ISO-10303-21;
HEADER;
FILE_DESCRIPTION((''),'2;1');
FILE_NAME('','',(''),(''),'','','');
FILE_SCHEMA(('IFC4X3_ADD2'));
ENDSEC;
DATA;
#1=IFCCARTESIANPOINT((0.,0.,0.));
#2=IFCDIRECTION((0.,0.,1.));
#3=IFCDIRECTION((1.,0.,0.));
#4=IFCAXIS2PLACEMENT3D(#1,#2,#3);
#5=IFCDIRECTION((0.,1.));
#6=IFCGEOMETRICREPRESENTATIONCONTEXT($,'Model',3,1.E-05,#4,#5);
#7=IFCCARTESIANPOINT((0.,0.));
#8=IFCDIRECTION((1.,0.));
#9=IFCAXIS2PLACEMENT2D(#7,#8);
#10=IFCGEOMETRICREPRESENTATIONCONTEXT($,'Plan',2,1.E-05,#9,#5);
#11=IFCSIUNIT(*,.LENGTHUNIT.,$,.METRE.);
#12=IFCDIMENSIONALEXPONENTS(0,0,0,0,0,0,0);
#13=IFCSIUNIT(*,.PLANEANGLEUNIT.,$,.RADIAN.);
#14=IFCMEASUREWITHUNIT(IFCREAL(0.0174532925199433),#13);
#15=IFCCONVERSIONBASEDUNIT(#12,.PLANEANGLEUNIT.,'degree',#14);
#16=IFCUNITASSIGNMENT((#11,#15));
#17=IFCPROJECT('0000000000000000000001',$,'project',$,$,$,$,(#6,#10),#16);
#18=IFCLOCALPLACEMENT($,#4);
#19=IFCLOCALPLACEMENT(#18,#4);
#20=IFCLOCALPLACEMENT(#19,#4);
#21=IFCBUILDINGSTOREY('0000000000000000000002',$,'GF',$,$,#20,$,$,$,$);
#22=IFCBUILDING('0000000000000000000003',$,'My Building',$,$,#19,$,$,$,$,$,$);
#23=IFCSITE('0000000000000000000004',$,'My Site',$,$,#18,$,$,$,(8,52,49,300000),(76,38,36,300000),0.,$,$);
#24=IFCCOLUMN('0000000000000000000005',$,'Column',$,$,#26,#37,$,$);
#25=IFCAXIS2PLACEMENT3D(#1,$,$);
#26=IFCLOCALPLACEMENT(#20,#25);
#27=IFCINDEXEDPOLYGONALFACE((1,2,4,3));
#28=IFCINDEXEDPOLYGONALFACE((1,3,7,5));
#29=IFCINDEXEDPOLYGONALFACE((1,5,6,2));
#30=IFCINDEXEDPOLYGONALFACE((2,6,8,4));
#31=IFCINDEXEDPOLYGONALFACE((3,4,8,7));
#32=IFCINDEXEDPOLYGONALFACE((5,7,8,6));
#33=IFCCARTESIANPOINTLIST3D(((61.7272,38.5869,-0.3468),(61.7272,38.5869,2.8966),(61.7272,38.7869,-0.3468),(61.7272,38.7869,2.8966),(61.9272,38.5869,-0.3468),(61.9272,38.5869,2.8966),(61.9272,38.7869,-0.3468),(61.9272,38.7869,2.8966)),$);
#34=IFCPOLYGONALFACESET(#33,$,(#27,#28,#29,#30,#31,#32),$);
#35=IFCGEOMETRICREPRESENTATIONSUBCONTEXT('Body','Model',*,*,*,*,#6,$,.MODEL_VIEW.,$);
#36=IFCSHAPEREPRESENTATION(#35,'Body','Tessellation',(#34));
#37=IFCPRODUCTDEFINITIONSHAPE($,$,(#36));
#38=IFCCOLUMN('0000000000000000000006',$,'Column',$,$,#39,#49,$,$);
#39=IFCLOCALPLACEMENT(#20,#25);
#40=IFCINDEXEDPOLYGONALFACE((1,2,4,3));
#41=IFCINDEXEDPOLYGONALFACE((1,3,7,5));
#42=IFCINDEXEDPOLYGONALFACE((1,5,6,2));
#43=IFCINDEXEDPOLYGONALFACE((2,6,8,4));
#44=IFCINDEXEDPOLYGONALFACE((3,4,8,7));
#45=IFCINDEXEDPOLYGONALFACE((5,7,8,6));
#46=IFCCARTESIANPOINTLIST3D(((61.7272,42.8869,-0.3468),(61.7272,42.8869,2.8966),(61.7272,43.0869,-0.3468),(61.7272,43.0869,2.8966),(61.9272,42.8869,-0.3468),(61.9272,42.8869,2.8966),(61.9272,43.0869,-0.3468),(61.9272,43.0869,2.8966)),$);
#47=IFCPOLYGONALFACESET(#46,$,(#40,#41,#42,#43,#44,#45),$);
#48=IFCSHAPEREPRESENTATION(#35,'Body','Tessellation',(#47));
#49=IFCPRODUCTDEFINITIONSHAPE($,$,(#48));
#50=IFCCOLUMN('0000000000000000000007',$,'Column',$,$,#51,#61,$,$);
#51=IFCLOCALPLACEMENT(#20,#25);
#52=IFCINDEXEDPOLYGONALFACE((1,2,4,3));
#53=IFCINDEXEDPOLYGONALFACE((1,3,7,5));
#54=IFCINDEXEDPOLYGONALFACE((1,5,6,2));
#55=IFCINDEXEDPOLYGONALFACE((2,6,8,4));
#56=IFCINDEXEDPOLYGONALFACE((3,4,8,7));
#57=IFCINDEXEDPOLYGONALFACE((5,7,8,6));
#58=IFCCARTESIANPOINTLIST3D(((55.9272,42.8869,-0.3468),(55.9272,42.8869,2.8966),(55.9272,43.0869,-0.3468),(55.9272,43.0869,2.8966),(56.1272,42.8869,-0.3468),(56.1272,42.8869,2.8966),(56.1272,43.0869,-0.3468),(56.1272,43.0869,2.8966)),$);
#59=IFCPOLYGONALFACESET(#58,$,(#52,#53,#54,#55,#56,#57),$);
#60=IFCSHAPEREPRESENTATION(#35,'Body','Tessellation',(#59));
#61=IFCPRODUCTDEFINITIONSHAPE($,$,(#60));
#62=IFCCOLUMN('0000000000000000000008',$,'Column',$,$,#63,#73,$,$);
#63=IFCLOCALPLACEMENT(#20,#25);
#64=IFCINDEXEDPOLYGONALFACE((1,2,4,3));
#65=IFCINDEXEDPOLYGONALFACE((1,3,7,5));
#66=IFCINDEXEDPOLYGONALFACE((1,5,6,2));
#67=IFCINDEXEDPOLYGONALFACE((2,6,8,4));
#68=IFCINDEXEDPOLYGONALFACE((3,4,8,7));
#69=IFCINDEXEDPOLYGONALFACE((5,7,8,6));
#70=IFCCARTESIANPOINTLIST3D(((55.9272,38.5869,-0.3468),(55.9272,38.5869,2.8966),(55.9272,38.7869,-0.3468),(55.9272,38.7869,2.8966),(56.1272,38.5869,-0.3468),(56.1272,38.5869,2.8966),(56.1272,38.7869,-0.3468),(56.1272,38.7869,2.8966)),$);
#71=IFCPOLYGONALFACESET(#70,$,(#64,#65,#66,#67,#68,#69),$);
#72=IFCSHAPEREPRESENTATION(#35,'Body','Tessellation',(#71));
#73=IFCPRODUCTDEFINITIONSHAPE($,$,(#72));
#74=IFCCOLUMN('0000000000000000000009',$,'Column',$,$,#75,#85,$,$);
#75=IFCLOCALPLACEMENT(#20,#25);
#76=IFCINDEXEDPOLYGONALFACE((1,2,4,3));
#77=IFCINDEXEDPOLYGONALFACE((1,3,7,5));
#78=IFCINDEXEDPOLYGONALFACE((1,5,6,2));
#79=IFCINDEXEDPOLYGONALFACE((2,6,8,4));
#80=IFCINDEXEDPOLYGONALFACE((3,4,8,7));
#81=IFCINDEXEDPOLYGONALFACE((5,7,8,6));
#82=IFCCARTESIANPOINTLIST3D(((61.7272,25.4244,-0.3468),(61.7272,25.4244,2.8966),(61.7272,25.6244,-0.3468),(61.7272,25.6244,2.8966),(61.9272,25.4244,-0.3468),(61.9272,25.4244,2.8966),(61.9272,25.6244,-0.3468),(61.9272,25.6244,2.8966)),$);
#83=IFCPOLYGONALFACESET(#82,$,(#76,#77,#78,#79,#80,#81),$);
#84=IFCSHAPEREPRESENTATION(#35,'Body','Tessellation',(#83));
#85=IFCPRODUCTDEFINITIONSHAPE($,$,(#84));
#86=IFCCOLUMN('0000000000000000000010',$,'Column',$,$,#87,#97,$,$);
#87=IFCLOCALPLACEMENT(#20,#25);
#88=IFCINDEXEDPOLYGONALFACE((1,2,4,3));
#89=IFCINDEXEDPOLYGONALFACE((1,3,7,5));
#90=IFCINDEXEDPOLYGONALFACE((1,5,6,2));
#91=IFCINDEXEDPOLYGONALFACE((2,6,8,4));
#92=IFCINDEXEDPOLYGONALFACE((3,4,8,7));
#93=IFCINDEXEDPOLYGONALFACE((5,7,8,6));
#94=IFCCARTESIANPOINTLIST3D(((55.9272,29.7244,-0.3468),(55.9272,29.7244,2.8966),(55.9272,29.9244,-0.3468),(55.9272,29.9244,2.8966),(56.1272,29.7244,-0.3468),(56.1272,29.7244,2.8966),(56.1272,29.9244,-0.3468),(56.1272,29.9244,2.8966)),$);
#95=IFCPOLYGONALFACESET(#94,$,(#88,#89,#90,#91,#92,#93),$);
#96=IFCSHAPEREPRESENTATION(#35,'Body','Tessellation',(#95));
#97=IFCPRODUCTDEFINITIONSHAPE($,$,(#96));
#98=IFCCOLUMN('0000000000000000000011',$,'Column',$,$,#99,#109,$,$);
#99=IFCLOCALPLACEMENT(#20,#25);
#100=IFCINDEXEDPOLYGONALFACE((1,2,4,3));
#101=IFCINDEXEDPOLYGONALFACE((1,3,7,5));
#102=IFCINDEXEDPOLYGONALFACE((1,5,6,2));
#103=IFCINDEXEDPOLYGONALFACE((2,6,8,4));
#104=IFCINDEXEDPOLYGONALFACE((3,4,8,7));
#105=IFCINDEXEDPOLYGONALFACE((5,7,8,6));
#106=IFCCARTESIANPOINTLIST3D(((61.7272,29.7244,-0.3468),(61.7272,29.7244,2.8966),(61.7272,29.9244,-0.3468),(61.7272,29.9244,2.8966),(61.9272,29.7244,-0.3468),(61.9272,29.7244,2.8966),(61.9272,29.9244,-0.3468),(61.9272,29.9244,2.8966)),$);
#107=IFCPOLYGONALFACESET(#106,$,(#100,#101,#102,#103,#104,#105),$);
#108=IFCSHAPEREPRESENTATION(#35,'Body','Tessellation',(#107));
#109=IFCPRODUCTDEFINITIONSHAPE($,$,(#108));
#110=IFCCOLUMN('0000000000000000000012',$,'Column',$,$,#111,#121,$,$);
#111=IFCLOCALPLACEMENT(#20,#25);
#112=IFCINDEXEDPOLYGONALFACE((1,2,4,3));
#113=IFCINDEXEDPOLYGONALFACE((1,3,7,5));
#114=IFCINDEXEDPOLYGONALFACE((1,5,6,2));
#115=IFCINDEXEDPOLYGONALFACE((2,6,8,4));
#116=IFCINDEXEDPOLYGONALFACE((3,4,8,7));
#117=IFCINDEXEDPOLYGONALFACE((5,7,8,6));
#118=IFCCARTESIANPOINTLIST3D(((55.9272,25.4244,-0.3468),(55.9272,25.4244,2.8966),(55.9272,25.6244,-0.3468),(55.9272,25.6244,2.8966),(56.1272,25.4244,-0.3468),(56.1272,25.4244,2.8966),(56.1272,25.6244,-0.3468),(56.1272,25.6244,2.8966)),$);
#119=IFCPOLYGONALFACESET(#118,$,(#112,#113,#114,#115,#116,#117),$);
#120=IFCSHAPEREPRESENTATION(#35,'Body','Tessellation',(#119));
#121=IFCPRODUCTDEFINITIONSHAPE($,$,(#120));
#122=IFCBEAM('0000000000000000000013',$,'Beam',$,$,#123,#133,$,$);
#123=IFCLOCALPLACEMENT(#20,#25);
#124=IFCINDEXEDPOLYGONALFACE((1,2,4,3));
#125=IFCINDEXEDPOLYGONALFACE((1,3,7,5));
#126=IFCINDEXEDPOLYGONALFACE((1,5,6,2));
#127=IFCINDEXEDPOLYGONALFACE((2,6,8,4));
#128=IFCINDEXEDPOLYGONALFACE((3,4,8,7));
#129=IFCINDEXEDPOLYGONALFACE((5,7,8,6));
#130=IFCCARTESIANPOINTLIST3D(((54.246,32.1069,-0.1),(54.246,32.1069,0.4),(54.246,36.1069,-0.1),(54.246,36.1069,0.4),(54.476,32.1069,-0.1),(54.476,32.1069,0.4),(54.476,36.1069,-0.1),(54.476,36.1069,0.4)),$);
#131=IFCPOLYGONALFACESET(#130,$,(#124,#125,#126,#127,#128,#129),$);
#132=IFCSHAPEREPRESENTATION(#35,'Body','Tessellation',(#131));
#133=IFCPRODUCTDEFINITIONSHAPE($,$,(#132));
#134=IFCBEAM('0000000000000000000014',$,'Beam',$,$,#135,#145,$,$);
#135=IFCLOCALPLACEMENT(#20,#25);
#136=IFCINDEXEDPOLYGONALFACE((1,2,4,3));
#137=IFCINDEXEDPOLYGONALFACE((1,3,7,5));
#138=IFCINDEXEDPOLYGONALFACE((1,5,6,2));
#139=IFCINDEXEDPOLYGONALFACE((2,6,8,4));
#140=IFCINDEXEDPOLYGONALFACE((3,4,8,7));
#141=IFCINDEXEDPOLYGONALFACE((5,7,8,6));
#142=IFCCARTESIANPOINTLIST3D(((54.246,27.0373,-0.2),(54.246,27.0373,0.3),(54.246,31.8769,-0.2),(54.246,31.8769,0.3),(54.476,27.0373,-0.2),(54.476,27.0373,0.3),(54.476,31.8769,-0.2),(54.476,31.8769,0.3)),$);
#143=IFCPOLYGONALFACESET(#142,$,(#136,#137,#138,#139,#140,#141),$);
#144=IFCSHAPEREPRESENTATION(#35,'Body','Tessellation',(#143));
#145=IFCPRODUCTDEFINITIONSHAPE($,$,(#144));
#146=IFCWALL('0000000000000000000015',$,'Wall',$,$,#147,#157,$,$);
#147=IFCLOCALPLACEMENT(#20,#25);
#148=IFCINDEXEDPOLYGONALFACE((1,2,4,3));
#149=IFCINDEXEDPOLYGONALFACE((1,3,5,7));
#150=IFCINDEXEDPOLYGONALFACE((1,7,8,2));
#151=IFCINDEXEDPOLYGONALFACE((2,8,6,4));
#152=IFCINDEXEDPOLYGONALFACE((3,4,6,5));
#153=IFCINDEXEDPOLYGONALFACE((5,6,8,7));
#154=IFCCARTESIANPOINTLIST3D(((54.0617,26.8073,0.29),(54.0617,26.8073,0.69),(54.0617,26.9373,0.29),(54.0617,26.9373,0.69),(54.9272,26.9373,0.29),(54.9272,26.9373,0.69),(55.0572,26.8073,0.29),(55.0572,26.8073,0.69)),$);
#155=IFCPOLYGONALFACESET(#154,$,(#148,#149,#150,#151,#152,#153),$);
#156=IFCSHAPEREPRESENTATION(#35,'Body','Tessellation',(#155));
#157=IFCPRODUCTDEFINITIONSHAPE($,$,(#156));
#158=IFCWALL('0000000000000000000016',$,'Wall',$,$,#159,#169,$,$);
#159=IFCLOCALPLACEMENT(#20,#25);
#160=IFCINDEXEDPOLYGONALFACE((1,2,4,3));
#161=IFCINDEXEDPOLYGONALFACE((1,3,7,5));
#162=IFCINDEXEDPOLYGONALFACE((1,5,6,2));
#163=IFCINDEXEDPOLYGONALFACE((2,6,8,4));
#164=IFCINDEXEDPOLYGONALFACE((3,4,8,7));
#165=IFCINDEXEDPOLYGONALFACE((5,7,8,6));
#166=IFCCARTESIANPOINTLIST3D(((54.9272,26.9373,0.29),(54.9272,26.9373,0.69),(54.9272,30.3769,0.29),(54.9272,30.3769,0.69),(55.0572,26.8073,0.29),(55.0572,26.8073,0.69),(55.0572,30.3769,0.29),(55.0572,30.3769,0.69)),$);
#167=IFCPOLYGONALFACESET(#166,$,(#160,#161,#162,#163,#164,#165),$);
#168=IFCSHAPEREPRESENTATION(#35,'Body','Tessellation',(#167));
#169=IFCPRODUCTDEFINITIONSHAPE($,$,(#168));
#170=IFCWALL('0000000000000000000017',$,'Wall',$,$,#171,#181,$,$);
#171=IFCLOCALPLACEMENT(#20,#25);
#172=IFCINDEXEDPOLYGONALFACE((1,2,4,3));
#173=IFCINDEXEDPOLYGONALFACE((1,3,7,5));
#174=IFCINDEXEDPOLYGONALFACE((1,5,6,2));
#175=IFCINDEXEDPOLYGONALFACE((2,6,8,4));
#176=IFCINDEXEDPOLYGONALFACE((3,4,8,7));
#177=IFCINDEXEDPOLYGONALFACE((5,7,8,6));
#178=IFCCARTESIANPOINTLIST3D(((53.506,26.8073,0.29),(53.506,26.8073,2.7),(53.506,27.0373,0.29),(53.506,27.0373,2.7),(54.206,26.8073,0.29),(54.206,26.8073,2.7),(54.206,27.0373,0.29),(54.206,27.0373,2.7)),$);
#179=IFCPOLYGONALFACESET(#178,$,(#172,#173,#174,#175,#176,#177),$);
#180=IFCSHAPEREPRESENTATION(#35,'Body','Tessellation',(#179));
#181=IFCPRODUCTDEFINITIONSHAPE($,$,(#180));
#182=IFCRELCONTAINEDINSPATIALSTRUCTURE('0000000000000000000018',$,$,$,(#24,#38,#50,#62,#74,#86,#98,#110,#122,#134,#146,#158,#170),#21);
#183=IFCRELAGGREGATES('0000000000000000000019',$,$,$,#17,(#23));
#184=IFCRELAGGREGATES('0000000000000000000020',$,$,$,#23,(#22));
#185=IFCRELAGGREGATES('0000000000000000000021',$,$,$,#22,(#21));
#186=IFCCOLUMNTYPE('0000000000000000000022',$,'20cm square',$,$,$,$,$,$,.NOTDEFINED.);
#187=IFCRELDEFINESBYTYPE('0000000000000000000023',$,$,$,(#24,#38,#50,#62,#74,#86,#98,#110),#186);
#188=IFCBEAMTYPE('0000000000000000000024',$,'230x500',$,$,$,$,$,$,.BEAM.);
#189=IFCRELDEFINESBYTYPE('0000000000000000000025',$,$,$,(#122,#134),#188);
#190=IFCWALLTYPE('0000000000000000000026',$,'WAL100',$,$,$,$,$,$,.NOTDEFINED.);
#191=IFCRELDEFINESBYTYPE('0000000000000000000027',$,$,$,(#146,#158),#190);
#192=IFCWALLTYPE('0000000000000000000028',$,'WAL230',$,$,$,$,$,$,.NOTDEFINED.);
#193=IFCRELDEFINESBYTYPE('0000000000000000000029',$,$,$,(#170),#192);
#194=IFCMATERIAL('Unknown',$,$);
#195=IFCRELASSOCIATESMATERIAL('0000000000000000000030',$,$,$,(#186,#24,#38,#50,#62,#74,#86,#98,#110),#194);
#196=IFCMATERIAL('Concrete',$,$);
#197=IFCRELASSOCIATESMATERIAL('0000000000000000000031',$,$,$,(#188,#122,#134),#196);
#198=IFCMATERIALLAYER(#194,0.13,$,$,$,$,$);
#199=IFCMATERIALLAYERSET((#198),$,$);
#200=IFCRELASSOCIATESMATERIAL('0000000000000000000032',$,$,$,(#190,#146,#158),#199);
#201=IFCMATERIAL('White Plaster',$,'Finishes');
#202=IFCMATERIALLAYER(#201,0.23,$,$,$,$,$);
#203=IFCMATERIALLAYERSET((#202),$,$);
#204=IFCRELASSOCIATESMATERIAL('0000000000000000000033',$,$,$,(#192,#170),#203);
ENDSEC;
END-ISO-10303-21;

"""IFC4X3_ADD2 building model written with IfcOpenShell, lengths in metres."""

from ifc_helpers import new_model, entity, si_unit, converted_unit, direction, frame, origin_with_axes, origin_2d_with_axis, place, context, subcontext, project, spatial, line, indexed_curve, rectangle, outline, extrude, material, layer, layer_set, layer_usage, material_profile, profile_set, profile_usage, type_object, element, save


model = new_model("IFC4X3_ADD2")

# Units and contexts
model_context = context("Model", 3, precision=1e-05, world=origin_with_axes(), true_north=direction((0.0, 1.0)))
plan_context = context("Plan", 2, precision=1e-05, world=origin_2d_with_axis(), true_north=direction((0.0, 1.0)))
body_context_1 = subcontext(model_context, "Body", "Model", "MODEL_VIEW")
ifc_project = project(units=[si_unit("LENGTHUNIT", "METRE"), converted_unit("PLANEANGLEUNIT", "degree", entity("IfcReal", 0.0174532925199433), si_unit("PLANEANGLEUNIT", "RADIAN"), dimensions=[0, 0, 0, 0, 0, 0, 0])], contexts=[model_context, plan_context])

# Site, building, storey
site_placement = place(None, origin_with_axes())
site = spatial("IfcSite", under=ifc_project, at=site_placement, Name="My Site", RefLatitude=(8, 52, 49, 300000), RefLongitude=(76, 38, 36, 300000), RefElevation=0.0)
building_placement = place(site_placement, origin_with_axes())
building = spatial("IfcBuilding", under=site, at=building_placement, Name="My Building")
storey_placement = place(building_placement, origin_with_axes())
storey = spatial("IfcBuildingStorey", under=building, at=storey_placement, Name="GF")

# Columns
ifc_material_1 = material(Name="Unknown")
ifc_material_profile_1 = material_profile(ifc_material_1, outline(indexed_curve([(-0.1, 0.1), (0.1, 0.1), (0.1, -0.1), (-0.1, -0.1), (-0.1, 0.1)])))
ifc_profile_set_1 = profile_set([ifc_material_profile_1])
ifc_profile_usage_1 = profile_usage(ifc_profile_set_1, cardinal=5)
column_type = type_object("IfcColumnType", Name="20cm square", PredefinedType="NOTDEFINED", material=ifc_profile_set_1)
column_1_placement = place(storey_placement, frame((61.8272, 38.6869, -0.3468), z_axis=(0.0, 0.0, 1.0), x_axis=(1.0, 0.0, 0.0)))
element("IfcColumn", 1, at=column_1_placement, inside=storey, type_object=column_type, material=ifc_profile_usage_1, Name="Column", context=body_context_1, shape_type="SweptSolid", body=[
    extrude(outline(indexed_curve([(-0.1, 0.1), (0.1, 0.1), (0.1, -0.1), (-0.1, -0.1), (-0.1, 0.1)])), origin_with_axes(), (0.0, 0.0, 1.0), 3.2434),
])
ifc_profile_usage_2 = profile_usage(ifc_profile_set_1, cardinal=5)
column_2_placement = place(storey_placement, frame((61.8272, 42.9869, -0.3468), z_axis=(0.0, 0.0, 1.0), x_axis=(1.0, 0.0, 0.0)))
element("IfcColumn", 2, at=column_2_placement, inside=storey, type_object=column_type, material=ifc_profile_usage_2, Name="Column", context=body_context_1, shape_type="SweptSolid", body=[
    extrude(outline(indexed_curve([(-0.1, 0.1), (0.1, 0.1), (0.1, -0.1), (-0.1, -0.1), (-0.1, 0.1)])), origin_with_axes(), (0.0, 0.0, 1.0), 3.2434),
])
ifc_profile_usage_3 = profile_usage(ifc_profile_set_1, cardinal=5)
column_3_placement = place(storey_placement, frame((56.0272, 42.9869, -0.3468), z_axis=(0.0, 0.0, 1.0), x_axis=(1.0, 0.0, 0.0)))
element("IfcColumn", 3, at=column_3_placement, inside=storey, type_object=column_type, material=ifc_profile_usage_3, Name="Column", context=body_context_1, shape_type="SweptSolid", body=[
    extrude(outline(indexed_curve([(-0.1, 0.1), (0.1, 0.1), (0.1, -0.1), (-0.1, -0.1), (-0.1, 0.1)])), origin_with_axes(), (0.0, 0.0, 1.0), 3.2434),
])
ifc_profile_usage_4 = profile_usage(ifc_profile_set_1, cardinal=5)
column_4_placement = place(storey_placement, frame((56.0272, 38.6869, -0.3468), z_axis=(0.0, 0.0, 1.0), x_axis=(1.0, 0.0, 0.0)))
element("IfcColumn", 4, at=column_4_placement, inside=storey, type_object=column_type, material=ifc_profile_usage_4, Name="Column", context=body_context_1, shape_type="SweptSolid", body=[
    extrude(outline(indexed_curve([(-0.1, 0.1), (0.1, 0.1), (0.1, -0.1), (-0.1, -0.1), (-0.1, 0.1)])), origin_with_axes(), (0.0, 0.0, 1.0), 3.2434),
])
ifc_profile_usage_5 = profile_usage(ifc_profile_set_1, cardinal=5)
column_5_placement = place(storey_placement, frame((61.8272, 25.5244, -0.3468), z_axis=(0.0, 0.0, 1.0), x_axis=(1.0, 0.0, 0.0)))
element("IfcColumn", 5, at=column_5_placement, inside=storey, type_object=column_type, material=ifc_profile_usage_5, Name="Column", context=body_context_1, shape_type="SweptSolid", body=[
    extrude(outline(indexed_curve([(-0.1, 0.1), (0.1, 0.1), (0.1, -0.1), (-0.1, -0.1), (-0.1, 0.1)])), origin_with_axes(), (0.0, 0.0, 1.0), 3.2434),
])
ifc_profile_usage_6 = profile_usage(ifc_profile_set_1, cardinal=5)
column_6_placement = place(storey_placement, frame((56.0272, 29.8244, -0.3468), z_axis=(0.0, 0.0, 1.0), x_axis=(1.0, 0.0, 0.0)))
element("IfcColumn", 6, at=column_6_placement, inside=storey, type_object=column_type, material=ifc_profile_usage_6, Name="Column", context=body_context_1, shape_type="SweptSolid", body=[
    extrude(outline(indexed_curve([(-0.1, 0.1), (0.1, 0.1), (0.1, -0.1), (-0.1, -0.1), (-0.1, 0.1)])), origin_with_axes(), (0.0, 0.0, 1.0), 3.2434),
])
ifc_profile_usage_7 = profile_usage(ifc_profile_set_1, cardinal=5)
column_7_placement = place(storey_placement, frame((61.8272, 29.8244, -0.3468), z_axis=(0.0, 0.0, 1.0), x_axis=(1.0, 0.0, 0.0)))
element("IfcColumn", 7, at=column_7_placement, inside=storey, type_object=column_type, material=ifc_profile_usage_7, Name="Column", context=body_context_1, shape_type="SweptSolid", body=[
    extrude(outline(indexed_curve([(-0.1, 0.1), (0.1, 0.1), (0.1, -0.1), (-0.1, -0.1), (-0.1, 0.1)])), origin_with_axes(), (0.0, 0.0, 1.0), 3.2434),
])
ifc_profile_usage_8 = profile_usage(ifc_profile_set_1, cardinal=5)
column_8_placement = place(storey_placement, frame((56.0272, 25.5244, -0.3468), z_axis=(0.0, 0.0, 1.0), x_axis=(1.0, 0.0, 0.0)))
element("IfcColumn", 8, at=column_8_placement, inside=storey, type_object=column_type, material=ifc_profile_usage_8, Name="Column", context=body_context_1, shape_type="SweptSolid", body=[
    extrude(outline(indexed_curve([(-0.1, 0.1), (0.1, 0.1), (0.1, -0.1), (-0.1, -0.1), (-0.1, 0.1)])), origin_with_axes(), (0.0, 0.0, 1.0), 3.2434),
])

# Beams
ifc_material_2 = material(Name="Concrete")
ifc_material_profile_2 = material_profile(ifc_material_2, rectangle(XDim=0.23, YDim=0.5))
ifc_profile_set_2 = profile_set([ifc_material_profile_2])
ifc_profile_usage_9 = profile_usage(ifc_profile_set_2, cardinal=5)
beam_type = type_object("IfcBeamType", Name="230x500", PredefinedType="BEAM", material=ifc_profile_set_2)
beam_1_placement = place(storey_placement, frame((54.361, 32.1069, 0.15), z_axis=(0.0, 1.0, 0.0), x_axis=(-1.0, 0.0, 0.0)))
element("IfcBeam", 9, at=beam_1_placement, inside=storey, type_object=beam_type, material=ifc_profile_usage_9, Name="Beam", context=body_context_1, shape_type="SweptSolid", body=[
    extrude(rectangle(XDim=0.23, YDim=0.5), origin_with_axes(), (0.0, 0.0, 1.0), 4.0),
])
ifc_profile_usage_10 = profile_usage(ifc_profile_set_2, cardinal=5)
beam_2_placement = place(storey_placement, frame((54.361, 27.0373, 0.05), z_axis=(0.0, 1.0, 0.0), x_axis=(-1.0, 0.0, 0.0)))
element("IfcBeam", 10, at=beam_2_placement, inside=storey, type_object=beam_type, material=ifc_profile_usage_10, Name="Beam", context=body_context_1, shape_type="SweptSolid", body=[
    extrude(rectangle(XDim=0.23, YDim=0.5), origin_with_axes(), (0.0, 0.0, 1.0), 4.8396),
])

# Walls
ifc_layer_1 = layer(ifc_material_1, 0.13)
ifc_layer_set_1 = layer_set([ifc_layer_1])
ifc_layer_usage_1 = layer_usage(ifc_layer_set_1, "AXIS2", "NEGATIVE", 0.0)
wall_type_1 = type_object("IfcWallType", Name="WAL100", PredefinedType="NOTDEFINED", material=ifc_layer_set_1)
wall_1_placement = place(storey_placement, frame((54.9272, 26.8073, 0.29), z_axis=(0.0, 0.0, 1.0), x_axis=(-1.0, 0.0, 0.0)))
element("IfcWall", 11, at=wall_1_placement, inside=storey, type_object=wall_type_1, material=ifc_layer_usage_1, Name="Wall", context=body_context_1, shape_type="SweptSolid", body=[
    extrude(outline(indexed_curve([(0.0, -0.13), (-0.13, 0.0), (0.8656, 0.0), (0.8656, -0.13)], segments=[line(1, 2, 3, 4, 1)])), origin_with_axes(), (0.0, 0.0, 1.0), 0.4),
])
ifc_layer_usage_2 = layer_usage(ifc_layer_set_1, "AXIS2", "NEGATIVE", 0.0)
wall_2_placement = place(storey_placement, frame((54.9272, 26.8073, 0.29), z_axis=(0.0, 0.0, 1.0), x_axis=(0.000001, 1.0, 0.0)))
element("IfcWall", 12, at=wall_2_placement, inside=storey, type_object=wall_type_1, material=ifc_layer_usage_2, Name="Wall", context=body_context_1, shape_type="SweptSolid", body=[
    extrude(outline(indexed_curve([(0.0, -0.13), (0.13, 0.0), (3.5696, 0.0), (3.5696, -0.13)], segments=[line(1, 2, 3, 4, 1)])), origin_with_axes(), (0.0, 0.0, 1.0), 0.4),
])
ifc_material_3 = material(Name="White Plaster", Category="Finishes")
ifc_layer_2 = layer(ifc_material_3, 0.23)
ifc_layer_set_2 = layer_set([ifc_layer_2])
ifc_layer_usage_3 = layer_usage(ifc_layer_set_2, "AXIS2", "NEGATIVE", 0.0)
wall_type_2 = type_object("IfcWallType", Name="WAL230", PredefinedType="NOTDEFINED", material=ifc_layer_set_2)
wall_3_placement = place(storey_placement, frame((54.206, 26.8073, 0.29), z_axis=(0.0, 0.0, 1.0), x_axis=(-1.0, 0.0, 0.0)))
element("IfcWall", 13, at=wall_3_placement, inside=storey, type_object=wall_type_2, material=ifc_layer_usage_3, Name="Wall", context=body_context_1, shape_type="SweptSolid", body=[
    extrude(outline(indexed_curve([(0.0, -0.23), (0.0, 0.0), (0.7, 0.0), (0.7, -0.23)], segments=[line(1, 2, 3, 4, 1)])), origin_with_axes(), (0.0, 0.0, 1.0), 2.41),
])

save(model, "model.ifc")
